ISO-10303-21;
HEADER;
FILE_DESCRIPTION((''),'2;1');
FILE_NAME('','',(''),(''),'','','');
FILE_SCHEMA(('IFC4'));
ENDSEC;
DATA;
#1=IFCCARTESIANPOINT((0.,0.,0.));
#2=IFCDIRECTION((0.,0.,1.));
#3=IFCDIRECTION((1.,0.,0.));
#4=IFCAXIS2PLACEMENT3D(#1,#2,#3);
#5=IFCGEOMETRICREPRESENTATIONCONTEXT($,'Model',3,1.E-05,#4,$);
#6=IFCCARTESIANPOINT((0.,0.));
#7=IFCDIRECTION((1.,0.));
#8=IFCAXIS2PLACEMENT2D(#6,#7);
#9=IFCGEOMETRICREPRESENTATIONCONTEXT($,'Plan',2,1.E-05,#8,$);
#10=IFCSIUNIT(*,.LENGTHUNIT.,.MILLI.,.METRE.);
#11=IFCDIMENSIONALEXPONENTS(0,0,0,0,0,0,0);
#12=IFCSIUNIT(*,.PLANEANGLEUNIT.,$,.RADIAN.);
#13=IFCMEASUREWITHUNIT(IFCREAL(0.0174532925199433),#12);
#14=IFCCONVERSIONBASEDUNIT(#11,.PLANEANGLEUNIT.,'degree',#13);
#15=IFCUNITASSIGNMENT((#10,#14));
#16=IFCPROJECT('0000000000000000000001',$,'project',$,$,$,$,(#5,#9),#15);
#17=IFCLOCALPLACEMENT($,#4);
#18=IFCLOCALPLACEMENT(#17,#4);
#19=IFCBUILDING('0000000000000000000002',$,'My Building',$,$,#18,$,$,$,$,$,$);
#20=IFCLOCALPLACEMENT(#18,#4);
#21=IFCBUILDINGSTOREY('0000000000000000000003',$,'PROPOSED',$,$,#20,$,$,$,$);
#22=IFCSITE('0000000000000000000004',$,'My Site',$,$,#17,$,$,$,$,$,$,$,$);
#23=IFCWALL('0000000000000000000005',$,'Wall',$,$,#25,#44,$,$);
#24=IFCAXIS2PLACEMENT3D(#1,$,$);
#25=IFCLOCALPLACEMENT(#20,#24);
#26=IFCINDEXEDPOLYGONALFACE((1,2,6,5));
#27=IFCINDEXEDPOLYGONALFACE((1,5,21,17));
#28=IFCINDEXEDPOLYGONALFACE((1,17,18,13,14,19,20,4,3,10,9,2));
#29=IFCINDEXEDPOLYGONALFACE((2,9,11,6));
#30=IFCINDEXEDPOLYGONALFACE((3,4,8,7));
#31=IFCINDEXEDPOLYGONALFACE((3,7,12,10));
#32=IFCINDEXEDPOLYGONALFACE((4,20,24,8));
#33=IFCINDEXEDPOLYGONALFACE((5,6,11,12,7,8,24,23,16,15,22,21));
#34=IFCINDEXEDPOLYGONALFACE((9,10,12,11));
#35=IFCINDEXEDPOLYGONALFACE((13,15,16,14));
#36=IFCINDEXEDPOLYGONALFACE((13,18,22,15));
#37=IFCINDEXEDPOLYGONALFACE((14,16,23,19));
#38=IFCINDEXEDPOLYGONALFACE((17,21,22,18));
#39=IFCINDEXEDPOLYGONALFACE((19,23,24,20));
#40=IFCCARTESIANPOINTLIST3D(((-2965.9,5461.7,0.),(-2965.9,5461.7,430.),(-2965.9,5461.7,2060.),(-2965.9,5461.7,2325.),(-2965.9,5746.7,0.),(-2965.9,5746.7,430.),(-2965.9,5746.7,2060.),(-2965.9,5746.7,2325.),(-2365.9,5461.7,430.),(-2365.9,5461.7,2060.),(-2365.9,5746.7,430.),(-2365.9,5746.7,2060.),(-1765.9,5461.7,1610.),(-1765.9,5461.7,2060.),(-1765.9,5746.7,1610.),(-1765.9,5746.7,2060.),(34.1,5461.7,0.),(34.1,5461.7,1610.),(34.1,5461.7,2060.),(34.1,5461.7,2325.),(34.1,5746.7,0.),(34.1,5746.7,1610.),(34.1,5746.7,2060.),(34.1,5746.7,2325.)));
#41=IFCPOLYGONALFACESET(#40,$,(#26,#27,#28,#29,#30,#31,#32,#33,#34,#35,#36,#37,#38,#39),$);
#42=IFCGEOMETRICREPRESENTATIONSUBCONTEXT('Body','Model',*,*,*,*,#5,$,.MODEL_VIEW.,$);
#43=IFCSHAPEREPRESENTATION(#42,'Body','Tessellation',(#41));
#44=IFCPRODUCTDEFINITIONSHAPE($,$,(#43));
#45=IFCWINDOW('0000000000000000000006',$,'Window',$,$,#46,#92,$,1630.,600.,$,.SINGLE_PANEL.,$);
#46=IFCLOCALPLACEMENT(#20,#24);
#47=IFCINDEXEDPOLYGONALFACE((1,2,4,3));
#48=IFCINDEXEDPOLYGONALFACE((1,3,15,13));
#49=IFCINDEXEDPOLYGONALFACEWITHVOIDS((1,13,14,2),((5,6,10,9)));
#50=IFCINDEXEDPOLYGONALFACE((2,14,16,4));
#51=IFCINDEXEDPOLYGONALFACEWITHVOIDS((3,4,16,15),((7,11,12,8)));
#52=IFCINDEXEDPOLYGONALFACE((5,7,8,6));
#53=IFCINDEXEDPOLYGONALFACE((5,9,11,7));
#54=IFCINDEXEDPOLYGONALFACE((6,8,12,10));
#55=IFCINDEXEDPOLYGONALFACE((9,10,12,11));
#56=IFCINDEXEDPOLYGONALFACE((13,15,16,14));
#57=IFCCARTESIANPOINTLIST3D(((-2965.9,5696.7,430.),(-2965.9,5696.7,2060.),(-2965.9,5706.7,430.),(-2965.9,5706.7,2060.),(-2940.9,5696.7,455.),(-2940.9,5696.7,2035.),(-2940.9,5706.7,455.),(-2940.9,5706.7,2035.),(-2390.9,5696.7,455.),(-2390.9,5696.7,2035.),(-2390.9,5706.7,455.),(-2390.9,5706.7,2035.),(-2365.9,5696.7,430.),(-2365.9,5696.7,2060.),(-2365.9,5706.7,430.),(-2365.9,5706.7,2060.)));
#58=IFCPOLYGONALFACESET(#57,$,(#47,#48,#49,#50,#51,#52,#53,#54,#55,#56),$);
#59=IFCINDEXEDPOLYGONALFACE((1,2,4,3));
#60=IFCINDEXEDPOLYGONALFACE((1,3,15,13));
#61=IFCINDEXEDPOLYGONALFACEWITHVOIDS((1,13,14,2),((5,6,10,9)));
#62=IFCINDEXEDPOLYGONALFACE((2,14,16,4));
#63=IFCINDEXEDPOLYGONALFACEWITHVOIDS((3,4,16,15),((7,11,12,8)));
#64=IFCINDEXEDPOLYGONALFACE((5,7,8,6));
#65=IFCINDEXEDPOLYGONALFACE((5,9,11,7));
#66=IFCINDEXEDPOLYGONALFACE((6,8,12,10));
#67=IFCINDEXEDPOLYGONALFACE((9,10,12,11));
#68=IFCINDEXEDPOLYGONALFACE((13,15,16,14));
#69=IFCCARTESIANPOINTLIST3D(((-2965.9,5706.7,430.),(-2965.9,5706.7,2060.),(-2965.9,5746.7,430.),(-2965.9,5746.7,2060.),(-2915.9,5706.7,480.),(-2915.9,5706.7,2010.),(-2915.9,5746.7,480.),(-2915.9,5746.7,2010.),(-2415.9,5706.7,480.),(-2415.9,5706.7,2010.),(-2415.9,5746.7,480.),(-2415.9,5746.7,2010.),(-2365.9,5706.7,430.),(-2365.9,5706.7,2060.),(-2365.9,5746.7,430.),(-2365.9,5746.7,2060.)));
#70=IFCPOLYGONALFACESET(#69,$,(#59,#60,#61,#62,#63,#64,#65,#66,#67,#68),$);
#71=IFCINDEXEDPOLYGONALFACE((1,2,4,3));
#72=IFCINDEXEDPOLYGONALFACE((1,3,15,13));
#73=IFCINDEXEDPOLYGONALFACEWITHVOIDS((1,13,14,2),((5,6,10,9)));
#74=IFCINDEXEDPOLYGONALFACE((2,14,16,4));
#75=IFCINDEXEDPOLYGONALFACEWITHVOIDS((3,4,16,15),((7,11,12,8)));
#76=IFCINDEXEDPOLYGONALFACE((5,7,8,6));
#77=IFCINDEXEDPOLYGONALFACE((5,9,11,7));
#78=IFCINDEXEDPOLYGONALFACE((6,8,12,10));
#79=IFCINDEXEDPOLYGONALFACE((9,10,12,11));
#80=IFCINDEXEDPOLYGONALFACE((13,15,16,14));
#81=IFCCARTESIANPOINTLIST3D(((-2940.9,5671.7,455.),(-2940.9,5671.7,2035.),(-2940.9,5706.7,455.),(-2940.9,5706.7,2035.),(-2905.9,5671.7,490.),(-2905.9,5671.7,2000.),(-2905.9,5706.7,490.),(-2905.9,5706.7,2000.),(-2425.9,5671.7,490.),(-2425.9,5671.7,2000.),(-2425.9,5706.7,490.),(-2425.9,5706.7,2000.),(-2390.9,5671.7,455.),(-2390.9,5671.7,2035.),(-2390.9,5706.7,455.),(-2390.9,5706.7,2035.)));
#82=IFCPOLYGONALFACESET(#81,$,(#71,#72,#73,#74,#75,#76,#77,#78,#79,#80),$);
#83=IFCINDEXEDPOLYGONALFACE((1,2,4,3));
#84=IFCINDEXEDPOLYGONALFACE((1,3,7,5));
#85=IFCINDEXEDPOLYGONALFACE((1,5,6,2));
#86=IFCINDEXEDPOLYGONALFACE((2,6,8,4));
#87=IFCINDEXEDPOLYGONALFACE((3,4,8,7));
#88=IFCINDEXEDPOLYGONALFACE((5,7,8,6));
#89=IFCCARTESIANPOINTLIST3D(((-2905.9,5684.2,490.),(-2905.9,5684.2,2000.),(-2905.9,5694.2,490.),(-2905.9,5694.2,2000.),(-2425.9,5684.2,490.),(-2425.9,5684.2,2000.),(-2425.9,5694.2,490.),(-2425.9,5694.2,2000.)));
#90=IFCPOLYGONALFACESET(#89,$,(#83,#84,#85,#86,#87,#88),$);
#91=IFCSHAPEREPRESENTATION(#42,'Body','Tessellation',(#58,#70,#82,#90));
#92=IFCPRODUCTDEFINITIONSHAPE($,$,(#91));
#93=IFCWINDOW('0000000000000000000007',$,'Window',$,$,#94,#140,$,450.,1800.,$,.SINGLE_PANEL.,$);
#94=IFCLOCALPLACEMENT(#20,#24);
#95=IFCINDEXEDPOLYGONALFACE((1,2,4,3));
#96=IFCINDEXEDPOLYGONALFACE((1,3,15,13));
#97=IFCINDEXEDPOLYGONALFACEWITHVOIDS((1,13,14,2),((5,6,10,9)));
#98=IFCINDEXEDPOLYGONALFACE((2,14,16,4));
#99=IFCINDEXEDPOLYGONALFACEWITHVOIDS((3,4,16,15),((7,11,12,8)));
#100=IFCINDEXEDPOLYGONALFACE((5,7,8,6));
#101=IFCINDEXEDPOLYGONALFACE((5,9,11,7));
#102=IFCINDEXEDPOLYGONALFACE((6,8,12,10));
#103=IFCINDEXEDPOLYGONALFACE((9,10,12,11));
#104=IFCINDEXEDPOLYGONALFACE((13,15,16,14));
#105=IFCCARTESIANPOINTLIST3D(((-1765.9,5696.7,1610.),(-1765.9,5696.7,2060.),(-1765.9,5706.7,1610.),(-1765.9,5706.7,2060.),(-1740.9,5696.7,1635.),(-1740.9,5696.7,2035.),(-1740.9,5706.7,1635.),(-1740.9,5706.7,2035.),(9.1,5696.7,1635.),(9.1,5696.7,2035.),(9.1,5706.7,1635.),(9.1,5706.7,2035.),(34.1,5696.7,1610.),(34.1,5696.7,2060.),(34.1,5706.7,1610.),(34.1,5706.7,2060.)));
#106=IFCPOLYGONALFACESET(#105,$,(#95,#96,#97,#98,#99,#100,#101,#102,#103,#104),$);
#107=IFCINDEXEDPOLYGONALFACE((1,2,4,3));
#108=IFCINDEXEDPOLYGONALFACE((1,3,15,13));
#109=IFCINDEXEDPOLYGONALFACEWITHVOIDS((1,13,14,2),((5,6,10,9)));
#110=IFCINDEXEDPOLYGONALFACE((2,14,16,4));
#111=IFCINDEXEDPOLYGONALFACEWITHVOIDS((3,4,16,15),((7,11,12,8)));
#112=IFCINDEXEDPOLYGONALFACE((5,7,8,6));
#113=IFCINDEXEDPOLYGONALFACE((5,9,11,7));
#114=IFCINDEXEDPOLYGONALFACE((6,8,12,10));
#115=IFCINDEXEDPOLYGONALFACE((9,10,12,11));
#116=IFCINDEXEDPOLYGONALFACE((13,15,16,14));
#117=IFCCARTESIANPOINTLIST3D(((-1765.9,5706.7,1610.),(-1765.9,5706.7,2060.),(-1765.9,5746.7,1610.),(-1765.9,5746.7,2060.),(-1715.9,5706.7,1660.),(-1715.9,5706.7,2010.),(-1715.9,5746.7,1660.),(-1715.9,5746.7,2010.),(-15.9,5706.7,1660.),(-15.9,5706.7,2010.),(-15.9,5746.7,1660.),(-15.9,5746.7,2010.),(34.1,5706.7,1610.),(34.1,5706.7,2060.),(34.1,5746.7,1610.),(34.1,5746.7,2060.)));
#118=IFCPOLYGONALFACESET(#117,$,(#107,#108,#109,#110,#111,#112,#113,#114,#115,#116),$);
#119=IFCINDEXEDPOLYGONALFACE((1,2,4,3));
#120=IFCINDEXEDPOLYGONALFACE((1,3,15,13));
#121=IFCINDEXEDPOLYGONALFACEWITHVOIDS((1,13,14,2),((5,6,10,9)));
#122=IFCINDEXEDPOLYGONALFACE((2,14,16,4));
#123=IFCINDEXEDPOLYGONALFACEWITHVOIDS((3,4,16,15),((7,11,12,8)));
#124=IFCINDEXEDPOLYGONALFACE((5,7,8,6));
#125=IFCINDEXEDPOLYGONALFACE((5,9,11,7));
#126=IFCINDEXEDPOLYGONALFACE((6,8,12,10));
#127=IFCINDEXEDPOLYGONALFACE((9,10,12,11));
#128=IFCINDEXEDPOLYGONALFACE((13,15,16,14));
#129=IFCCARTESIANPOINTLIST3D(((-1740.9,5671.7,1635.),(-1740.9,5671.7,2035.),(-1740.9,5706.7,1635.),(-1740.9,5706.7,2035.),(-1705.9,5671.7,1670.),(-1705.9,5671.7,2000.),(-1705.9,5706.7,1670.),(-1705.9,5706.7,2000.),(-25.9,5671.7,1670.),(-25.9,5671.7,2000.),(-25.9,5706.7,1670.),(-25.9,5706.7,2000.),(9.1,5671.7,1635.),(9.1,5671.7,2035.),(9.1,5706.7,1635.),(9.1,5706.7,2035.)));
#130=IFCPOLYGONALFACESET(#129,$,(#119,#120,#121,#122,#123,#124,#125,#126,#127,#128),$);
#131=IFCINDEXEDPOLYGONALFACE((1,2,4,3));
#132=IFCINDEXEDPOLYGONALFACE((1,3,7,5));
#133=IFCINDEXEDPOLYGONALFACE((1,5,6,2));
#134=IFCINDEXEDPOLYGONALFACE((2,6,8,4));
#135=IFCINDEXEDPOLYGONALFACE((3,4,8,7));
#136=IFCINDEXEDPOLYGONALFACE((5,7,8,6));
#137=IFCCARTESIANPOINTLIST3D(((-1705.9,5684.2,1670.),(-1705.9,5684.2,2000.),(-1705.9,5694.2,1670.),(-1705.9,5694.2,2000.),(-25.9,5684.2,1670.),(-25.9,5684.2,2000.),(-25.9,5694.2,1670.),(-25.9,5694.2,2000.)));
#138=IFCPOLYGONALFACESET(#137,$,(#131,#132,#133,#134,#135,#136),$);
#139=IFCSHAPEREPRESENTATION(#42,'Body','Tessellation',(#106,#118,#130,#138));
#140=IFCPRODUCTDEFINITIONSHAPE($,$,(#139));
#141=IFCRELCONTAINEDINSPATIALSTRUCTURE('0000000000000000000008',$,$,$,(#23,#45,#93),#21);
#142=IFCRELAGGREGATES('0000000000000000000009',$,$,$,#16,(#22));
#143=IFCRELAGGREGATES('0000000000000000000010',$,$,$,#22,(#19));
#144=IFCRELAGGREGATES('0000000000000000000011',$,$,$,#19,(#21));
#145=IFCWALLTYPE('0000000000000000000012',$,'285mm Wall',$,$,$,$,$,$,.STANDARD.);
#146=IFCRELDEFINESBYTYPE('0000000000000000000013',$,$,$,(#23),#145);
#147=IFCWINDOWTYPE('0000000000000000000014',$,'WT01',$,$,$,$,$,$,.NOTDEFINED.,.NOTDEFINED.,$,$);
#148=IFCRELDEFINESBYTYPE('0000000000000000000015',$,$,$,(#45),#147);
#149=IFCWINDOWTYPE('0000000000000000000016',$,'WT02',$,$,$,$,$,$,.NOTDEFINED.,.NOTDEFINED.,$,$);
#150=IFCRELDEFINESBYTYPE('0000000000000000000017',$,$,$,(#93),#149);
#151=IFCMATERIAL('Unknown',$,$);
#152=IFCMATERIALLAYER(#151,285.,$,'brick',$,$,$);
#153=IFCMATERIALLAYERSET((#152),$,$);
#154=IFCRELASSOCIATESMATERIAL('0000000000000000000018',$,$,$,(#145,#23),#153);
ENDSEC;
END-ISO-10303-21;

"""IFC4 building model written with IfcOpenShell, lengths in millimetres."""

from ifc_helpers import new_model, entity, si_unit, converted_unit, frame, origin_with_axes, origin_2d_with_axis, place, context, subcontext, project, spatial, line, indexed_curve, outline, extrude, shape, source, transform, mapped, material, layer, layer_set, layer_usage, type_object, type_shapes, element, fill, save


model = new_model("IFC4")

# Units and contexts
model_context = context("Model", 3, precision=1e-05, world=origin_with_axes())
plan_context = context("Plan", 2, precision=1e-05, world=origin_2d_with_axis())
body_context_1 = subcontext(model_context, "Body", "Model", "MODEL_VIEW")
body_context_2 = subcontext(plan_context, "Body", "Plan", "PLAN_VIEW")
ifc_project = project(units=[si_unit("LENGTHUNIT", "METRE", prefix="MILLI"), converted_unit("PLANEANGLEUNIT", "degree", entity("IfcReal", 0.0174532925199433), si_unit("PLANEANGLEUNIT", "RADIAN"), dimensions=[0, 0, 0, 0, 0, 0, 0])], contexts=[model_context, plan_context])

# Site, building, storey
site_placement = place(None, origin_with_axes())
site = spatial("IfcSite", under=ifc_project, at=site_placement, Name="My Site")
building_placement = place(site_placement, origin_with_axes())
building = spatial("IfcBuilding", under=site, at=building_placement, Name="My Building")
storey_placement = place(building_placement, origin_with_axes())
storey = spatial("IfcBuildingStorey", under=building, at=storey_placement, Name="PROPOSED")

# Shared definitions
ifc_material = material(Name="Unknown")

# Shared definitions
ifc_layer_1 = layer(ifc_material, 285.0, Name="brick")
ifc_layer_set_1 = layer_set([ifc_layer_1])
wall_type_1 = type_object("IfcWallType", Name="285mm Wall", PredefinedType="STANDARD", material=ifc_layer_set_1)

# Wall, openings, windows
ifc_layer_usage_1 = layer_usage(ifc_layer_set_1, "AXIS2", "POSITIVE", 0.0)
wall_1_placement = place(storey_placement, frame((-2965.9, 5461.7, 0.0), z_axis=(0.0, 0.0, 1.0), x_axis=(1.0, 0.0, 0.0)))
wall_1 = element("IfcWall", 1, at=wall_1_placement, inside=storey, type_object=wall_type_1, material=ifc_layer_usage_1, Name="Wall", context=body_context_1, shape_type="SweptSolid", body=[
    extrude(outline(indexed_curve([(0.0, 0.0), (0.0, 285.0), (3000.0, 285.0), (3000.0, 0.0), (0.0, 0.0)], self_intersect=False)), origin_with_axes(), (0.0, 0.0, 1.0), 2325.0),
])
shared_shape_1 = source(origin_with_axes(), body_context_1, "Body", "SweptSolid", [
    extrude(outline(indexed_curve([(0.0, 0.0), (600.0, 0.0), (600.0, 1630.0), (0.0, 1630.0)], segments=[line(1, 2, 3, 4, 1)])), frame((0.0, -100.0, 0.0), z_axis=(0.0, -1.0, 0.0), x_axis=(1.0, 0.0, 0.0)), (0.0, 0.0, -1.0), 485.0),
])
opening_1_placement = place(wall_1_placement, frame((600.0, 335.0, 430.0), z_axis=(0.0, 0.0, 1.0), x_axis=(-1.0, 0.0, 0.0)))
opening_1 = element("IfcOpeningElement", 2, at=opening_1_placement, cuts=wall_1, PredefinedType="OPENING", context=body_context_1, shape_type="MappedRepresentation", body=[
    mapped(shared_shape_1, transform((0.0, 0.0, 0.0), x_axis=(1.0, 0.0, 0.0), y_axis=(0.0, 1.0, 0.0), z_axis=(0.0, 0.0, 1.0), scale=1.0)),
])
shared_shape_2 = source(origin_with_axes(), body_context_1, "Body", "SweptSolid", [
    extrude(outline(indexed_curve([(0.0, 0.0), (1800.0, 0.0), (1800.0, 450.0), (0.0, 450.0)], segments=[line(1, 2, 3, 4, 1)])), frame((0.0, -100.0, 0.0), z_axis=(0.0, -1.0, 0.0), x_axis=(1.0, 0.0, 0.0)), (0.0, 0.0, -1.0), 485.0),
])
opening_2_placement = place(wall_1_placement, frame((3000.0, 335.0, 1610.0), z_axis=(0.0, 0.0, 1.0), x_axis=(-1.0, 0.0, 0.0)))
opening_2 = element("IfcOpeningElement", 3, at=opening_2_placement, cuts=wall_1, PredefinedType="OPENING", context=body_context_1, shape_type="MappedRepresentation", body=[
    mapped(shared_shape_2, transform((0.0, 0.0, 0.0), x_axis=(1.0, 0.0, 0.0), y_axis=(0.0, 1.0, 0.0), z_axis=(0.0, 0.0, 1.0), scale=1.0)),
])
window_type_1 = type_object("IfcWindowType", Name="WT01", PartitioningType="NOTDEFINED", PredefinedType="NOTDEFINED")
shared_shape_3 = source(origin_with_axes(), body_context_1, "Body", "SweptSolid", [
    extrude(outline(indexed_curve([(0.0, 0.0), (600.0, 0.0), (600.0, 1630.0), (0.0, 1630.0)], segments=[line(1, 2, 3, 4, 1)]), holes=[indexed_curve([(25.0, 25.0), (575.0, 25.0), (575.0, 1605.0), (25.0, 1605.0)], segments=[line(1, 2, 3, 4, 1)])]), frame((0.0, 90.0, 0.0), z_axis=(0.0, -1.0, 0.0), x_axis=(1.0, 0.0, 0.0)), (0.0, 0.0, -1.0), 10.0),
    extrude(outline(indexed_curve([(0.0, 0.0), (600.0, 0.0), (600.0, 1630.0), (0.0, 1630.0)], segments=[line(1, 2, 3, 4, 1)]), holes=[indexed_curve([(50.0, 50.0), (550.0, 50.0), (550.0, 1580.0), (50.0, 1580.0)], segments=[line(1, 2, 3, 4, 1)])]), frame((0.0, 50.0, 0.0), z_axis=(0.0, -1.0, 0.0), x_axis=(1.0, 0.0, 0.0)), (0.0, 0.0, -1.0), 40.0),
    extrude(outline(indexed_curve([(0.0, 0.0), (550.0, 0.0), (550.0, 1580.0), (0.0, 1580.0)], segments=[line(1, 2, 3, 4, 1)]), holes=[indexed_curve([(35.0, 35.0), (515.0, 35.0), (515.0, 1545.0), (35.0, 1545.0)], segments=[line(1, 2, 3, 4, 1)])]), frame((25.0, 90.0, 25.0), z_axis=(0.0, -1.0, 0.0), x_axis=(1.0, 0.0, 0.0)), (0.0, 0.0, -1.0), 35.0),
    extrude(outline(indexed_curve([(35.0, 35.0), (515.0, 35.0), (515.0, 1545.0), (35.0, 1545.0)], segments=[line(1, 2, 3, 4, 1)])), frame((25.0, 102.5, 25.0), z_axis=(0.0, -1.0, 0.0), x_axis=(1.0, 0.0, 0.0)), (0.0, 0.0, -1.0), 10.0),
])
shared_shape_4 = source(origin_with_axes(), body_context_2, "Body", "Curve2D", [
    entity("IfcIndexedPolyCurve", entity("IfcCartesianPointList2D", [[50.0, 50.0], [550.0, 50.0]])),
    entity("IfcIndexedPolyCurve", entity("IfcCartesianPointList2D", [[0.0, 100.0], [25.0, 100.0], [25.0, 90.0], [50.0, 90.0], [50.0, 50.0], [0.0, 50.0]]), [entity("IfcLineIndex", [1, 2, 3, 4, 5, 6, 1])]),
    entity("IfcIndexedPolyCurve", entity("IfcCartesianPointList2D", [[600.0, 100.0], [575.0, 100.0], [575.0, 90.0], [550.0, 90.0], [550.0, 50.0], [600.0, 50.0]]), [entity("IfcLineIndex", [1, 2, 3, 4, 5, 6, 1])]),
    entity("IfcIndexedPolyCurve", entity("IfcCartesianPointList2D", [[25.0, 90.0], [60.0, 90.0], [60.0, 125.0], [25.0, 125.0]]), [entity("IfcLineIndex", [1, 2, 3, 4, 1])]),
    entity("IfcIndexedPolyCurve", entity("IfcCartesianPointList2D", [[575.0, 90.0], [540.0, 90.0], [540.0, 125.0], [575.0, 125.0]]), [entity("IfcLineIndex", [1, 2, 3, 4, 1])]),
    entity("IfcIndexedPolyCurve", entity("IfcCartesianPointList2D", [[60.0, 90.0], [540.0, 90.0]])),
    entity("IfcIndexedPolyCurve", entity("IfcCartesianPointList2D", [[60.0, 125.0], [540.0, 125.0]])),
    entity("IfcIndexedPolyCurve", entity("IfcCartesianPointList2D", [[60.0, 107.5], [540.0, 107.5]])),
])
type_shapes(window_type_1, [shared_shape_3, shared_shape_4])
window_1_placement = place(opening_1_placement, origin_with_axes())
window_1 = element("IfcWindow", 4, at=window_1_placement, inside=storey, type_object=window_type_1, Name="Window", OverallHeight=1630.0, OverallWidth=600.0, PartitioningType="SINGLE_PANEL", shapes=[
    shape(body_context_1, "Body", "MappedRepresentation", [mapped(shared_shape_3, transform((0.0, 0.0, 0.0), x_axis=(1.0, 0.0, 0.0), y_axis=(0.0, 1.0, 0.0), z_axis=(0.0, 0.0, 1.0), scale=1.0))]),
    shape(body_context_2, "Body", "MappedRepresentation", [mapped(shared_shape_4, transform((0.0, 0.0, 0.0), x_axis=(1.0, 0.0, 0.0), y_axis=(0.0, 1.0, 0.0), z_axis=(0.0, 0.0, 1.0), scale=1.0))]),
])
fill(opening_1, window_1)
window_type_2 = type_object("IfcWindowType", Name="WT02", PartitioningType="NOTDEFINED", PredefinedType="NOTDEFINED")
shared_shape_5 = source(origin_with_axes(), body_context_1, "Body", "SweptSolid", [
    extrude(outline(indexed_curve([(0.0, 0.0), (1800.0, 0.0), (1800.0, 450.0), (0.0, 450.0)], segments=[line(1, 2, 3, 4, 1)]), holes=[indexed_curve([(25.0, 25.0), (1775.0, 25.0), (1775.0, 425.0), (25.0, 425.0)], segments=[line(1, 2, 3, 4, 1)])]), frame((0.0, 90.0, 0.0), z_axis=(0.0, -1.0, 0.0), x_axis=(1.0, 0.0, 0.0)), (0.0, 0.0, -1.0), 10.0),
    extrude(outline(indexed_curve([(0.0, 0.0), (1800.0, 0.0), (1800.0, 450.0), (0.0, 450.0)], segments=[line(1, 2, 3, 4, 1)]), holes=[indexed_curve([(50.0, 50.0), (1750.0, 50.0), (1750.0, 400.0), (50.0, 400.0)], segments=[line(1, 2, 3, 4, 1)])]), frame((0.0, 50.0, 0.0), z_axis=(0.0, -1.0, 0.0), x_axis=(1.0, 0.0, 0.0)), (0.0, 0.0, -1.0), 40.0),
    extrude(outline(indexed_curve([(0.0, 0.0), (1750.0, 0.0), (1750.0, 400.0), (0.0, 400.0)], segments=[line(1, 2, 3, 4, 1)]), holes=[indexed_curve([(35.0, 35.0), (1715.0, 35.0), (1715.0, 365.0), (35.0, 365.0)], segments=[line(1, 2, 3, 4, 1)])]), frame((25.0, 90.0, 25.0), z_axis=(0.0, -1.0, 0.0), x_axis=(1.0, 0.0, 0.0)), (0.0, 0.0, -1.0), 35.0),
    extrude(outline(indexed_curve([(35.0, 35.0), (1715.0, 35.0), (1715.0, 365.0), (35.0, 365.0)], segments=[line(1, 2, 3, 4, 1)])), frame((25.0, 102.5, 25.0), z_axis=(0.0, -1.0, 0.0), x_axis=(1.0, 0.0, 0.0)), (0.0, 0.0, -1.0), 10.0),
])
shared_shape_6 = source(origin_with_axes(), body_context_2, "Body", "Curve2D", [
    entity("IfcIndexedPolyCurve", entity("IfcCartesianPointList2D", [[50.0, 50.0], [1750.0, 50.0]])),
    entity("IfcIndexedPolyCurve", entity("IfcCartesianPointList2D", [[0.0, 100.0], [25.0, 100.0], [25.0, 90.0], [50.0, 90.0], [50.0, 50.0], [0.0, 50.0]]), [entity("IfcLineIndex", [1, 2, 3, 4, 5, 6, 1])]),
    entity("IfcIndexedPolyCurve", entity("IfcCartesianPointList2D", [[1800.0, 100.0], [1775.0, 100.0], [1775.0, 90.0], [1750.0, 90.0], [1750.0, 50.0], [1800.0, 50.0]]), [entity("IfcLineIndex", [1, 2, 3, 4, 5, 6, 1])]),
    entity("IfcIndexedPolyCurve", entity("IfcCartesianPointList2D", [[25.0, 90.0], [60.0, 90.0], [60.0, 125.0], [25.0, 125.0]]), [entity("IfcLineIndex", [1, 2, 3, 4, 1])]),
    entity("IfcIndexedPolyCurve", entity("IfcCartesianPointList2D", [[1775.0, 90.0], [1740.0, 90.0], [1740.0, 125.0], [1775.0, 125.0]]), [entity("IfcLineIndex", [1, 2, 3, 4, 1])]),
    entity("IfcIndexedPolyCurve", entity("IfcCartesianPointList2D", [[60.0, 90.0], [1740.0, 90.0]])),
    entity("IfcIndexedPolyCurve", entity("IfcCartesianPointList2D", [[60.0, 125.0], [1740.0, 125.0]])),
    entity("IfcIndexedPolyCurve", entity("IfcCartesianPointList2D", [[60.0, 107.5], [1740.0, 107.5]])),
])
type_shapes(window_type_2, [shared_shape_5, shared_shape_6])
window_2_placement = place(opening_2_placement, frame((0.0, 0.0, 0.0), z_axis=(0.0, 0.0, 1.0), x_axis=(1.0, 0.0, 0.0)))
window_2 = element("IfcWindow", 5, at=window_2_placement, inside=storey, type_object=window_type_2, Name="Window", OverallHeight=450.0, OverallWidth=1800.0, PartitioningType="SINGLE_PANEL", shapes=[
    shape(body_context_1, "Body", "MappedRepresentation", [mapped(shared_shape_5, transform((0.0, 0.0, 0.0), x_axis=(1.0, 0.0, 0.0), y_axis=(0.0, 1.0, 0.0), z_axis=(0.0, 0.0, 1.0), scale=1.0))]),
    shape(body_context_2, "Body", "MappedRepresentation", [mapped(shared_shape_6, transform((0.0, 0.0, 0.0), x_axis=(1.0, 0.0, 0.0), y_axis=(0.0, 1.0, 0.0), z_axis=(0.0, 0.0, 1.0), scale=1.0))]),
])
fill(opening_2, window_2)

save(model, "model.ifc")
